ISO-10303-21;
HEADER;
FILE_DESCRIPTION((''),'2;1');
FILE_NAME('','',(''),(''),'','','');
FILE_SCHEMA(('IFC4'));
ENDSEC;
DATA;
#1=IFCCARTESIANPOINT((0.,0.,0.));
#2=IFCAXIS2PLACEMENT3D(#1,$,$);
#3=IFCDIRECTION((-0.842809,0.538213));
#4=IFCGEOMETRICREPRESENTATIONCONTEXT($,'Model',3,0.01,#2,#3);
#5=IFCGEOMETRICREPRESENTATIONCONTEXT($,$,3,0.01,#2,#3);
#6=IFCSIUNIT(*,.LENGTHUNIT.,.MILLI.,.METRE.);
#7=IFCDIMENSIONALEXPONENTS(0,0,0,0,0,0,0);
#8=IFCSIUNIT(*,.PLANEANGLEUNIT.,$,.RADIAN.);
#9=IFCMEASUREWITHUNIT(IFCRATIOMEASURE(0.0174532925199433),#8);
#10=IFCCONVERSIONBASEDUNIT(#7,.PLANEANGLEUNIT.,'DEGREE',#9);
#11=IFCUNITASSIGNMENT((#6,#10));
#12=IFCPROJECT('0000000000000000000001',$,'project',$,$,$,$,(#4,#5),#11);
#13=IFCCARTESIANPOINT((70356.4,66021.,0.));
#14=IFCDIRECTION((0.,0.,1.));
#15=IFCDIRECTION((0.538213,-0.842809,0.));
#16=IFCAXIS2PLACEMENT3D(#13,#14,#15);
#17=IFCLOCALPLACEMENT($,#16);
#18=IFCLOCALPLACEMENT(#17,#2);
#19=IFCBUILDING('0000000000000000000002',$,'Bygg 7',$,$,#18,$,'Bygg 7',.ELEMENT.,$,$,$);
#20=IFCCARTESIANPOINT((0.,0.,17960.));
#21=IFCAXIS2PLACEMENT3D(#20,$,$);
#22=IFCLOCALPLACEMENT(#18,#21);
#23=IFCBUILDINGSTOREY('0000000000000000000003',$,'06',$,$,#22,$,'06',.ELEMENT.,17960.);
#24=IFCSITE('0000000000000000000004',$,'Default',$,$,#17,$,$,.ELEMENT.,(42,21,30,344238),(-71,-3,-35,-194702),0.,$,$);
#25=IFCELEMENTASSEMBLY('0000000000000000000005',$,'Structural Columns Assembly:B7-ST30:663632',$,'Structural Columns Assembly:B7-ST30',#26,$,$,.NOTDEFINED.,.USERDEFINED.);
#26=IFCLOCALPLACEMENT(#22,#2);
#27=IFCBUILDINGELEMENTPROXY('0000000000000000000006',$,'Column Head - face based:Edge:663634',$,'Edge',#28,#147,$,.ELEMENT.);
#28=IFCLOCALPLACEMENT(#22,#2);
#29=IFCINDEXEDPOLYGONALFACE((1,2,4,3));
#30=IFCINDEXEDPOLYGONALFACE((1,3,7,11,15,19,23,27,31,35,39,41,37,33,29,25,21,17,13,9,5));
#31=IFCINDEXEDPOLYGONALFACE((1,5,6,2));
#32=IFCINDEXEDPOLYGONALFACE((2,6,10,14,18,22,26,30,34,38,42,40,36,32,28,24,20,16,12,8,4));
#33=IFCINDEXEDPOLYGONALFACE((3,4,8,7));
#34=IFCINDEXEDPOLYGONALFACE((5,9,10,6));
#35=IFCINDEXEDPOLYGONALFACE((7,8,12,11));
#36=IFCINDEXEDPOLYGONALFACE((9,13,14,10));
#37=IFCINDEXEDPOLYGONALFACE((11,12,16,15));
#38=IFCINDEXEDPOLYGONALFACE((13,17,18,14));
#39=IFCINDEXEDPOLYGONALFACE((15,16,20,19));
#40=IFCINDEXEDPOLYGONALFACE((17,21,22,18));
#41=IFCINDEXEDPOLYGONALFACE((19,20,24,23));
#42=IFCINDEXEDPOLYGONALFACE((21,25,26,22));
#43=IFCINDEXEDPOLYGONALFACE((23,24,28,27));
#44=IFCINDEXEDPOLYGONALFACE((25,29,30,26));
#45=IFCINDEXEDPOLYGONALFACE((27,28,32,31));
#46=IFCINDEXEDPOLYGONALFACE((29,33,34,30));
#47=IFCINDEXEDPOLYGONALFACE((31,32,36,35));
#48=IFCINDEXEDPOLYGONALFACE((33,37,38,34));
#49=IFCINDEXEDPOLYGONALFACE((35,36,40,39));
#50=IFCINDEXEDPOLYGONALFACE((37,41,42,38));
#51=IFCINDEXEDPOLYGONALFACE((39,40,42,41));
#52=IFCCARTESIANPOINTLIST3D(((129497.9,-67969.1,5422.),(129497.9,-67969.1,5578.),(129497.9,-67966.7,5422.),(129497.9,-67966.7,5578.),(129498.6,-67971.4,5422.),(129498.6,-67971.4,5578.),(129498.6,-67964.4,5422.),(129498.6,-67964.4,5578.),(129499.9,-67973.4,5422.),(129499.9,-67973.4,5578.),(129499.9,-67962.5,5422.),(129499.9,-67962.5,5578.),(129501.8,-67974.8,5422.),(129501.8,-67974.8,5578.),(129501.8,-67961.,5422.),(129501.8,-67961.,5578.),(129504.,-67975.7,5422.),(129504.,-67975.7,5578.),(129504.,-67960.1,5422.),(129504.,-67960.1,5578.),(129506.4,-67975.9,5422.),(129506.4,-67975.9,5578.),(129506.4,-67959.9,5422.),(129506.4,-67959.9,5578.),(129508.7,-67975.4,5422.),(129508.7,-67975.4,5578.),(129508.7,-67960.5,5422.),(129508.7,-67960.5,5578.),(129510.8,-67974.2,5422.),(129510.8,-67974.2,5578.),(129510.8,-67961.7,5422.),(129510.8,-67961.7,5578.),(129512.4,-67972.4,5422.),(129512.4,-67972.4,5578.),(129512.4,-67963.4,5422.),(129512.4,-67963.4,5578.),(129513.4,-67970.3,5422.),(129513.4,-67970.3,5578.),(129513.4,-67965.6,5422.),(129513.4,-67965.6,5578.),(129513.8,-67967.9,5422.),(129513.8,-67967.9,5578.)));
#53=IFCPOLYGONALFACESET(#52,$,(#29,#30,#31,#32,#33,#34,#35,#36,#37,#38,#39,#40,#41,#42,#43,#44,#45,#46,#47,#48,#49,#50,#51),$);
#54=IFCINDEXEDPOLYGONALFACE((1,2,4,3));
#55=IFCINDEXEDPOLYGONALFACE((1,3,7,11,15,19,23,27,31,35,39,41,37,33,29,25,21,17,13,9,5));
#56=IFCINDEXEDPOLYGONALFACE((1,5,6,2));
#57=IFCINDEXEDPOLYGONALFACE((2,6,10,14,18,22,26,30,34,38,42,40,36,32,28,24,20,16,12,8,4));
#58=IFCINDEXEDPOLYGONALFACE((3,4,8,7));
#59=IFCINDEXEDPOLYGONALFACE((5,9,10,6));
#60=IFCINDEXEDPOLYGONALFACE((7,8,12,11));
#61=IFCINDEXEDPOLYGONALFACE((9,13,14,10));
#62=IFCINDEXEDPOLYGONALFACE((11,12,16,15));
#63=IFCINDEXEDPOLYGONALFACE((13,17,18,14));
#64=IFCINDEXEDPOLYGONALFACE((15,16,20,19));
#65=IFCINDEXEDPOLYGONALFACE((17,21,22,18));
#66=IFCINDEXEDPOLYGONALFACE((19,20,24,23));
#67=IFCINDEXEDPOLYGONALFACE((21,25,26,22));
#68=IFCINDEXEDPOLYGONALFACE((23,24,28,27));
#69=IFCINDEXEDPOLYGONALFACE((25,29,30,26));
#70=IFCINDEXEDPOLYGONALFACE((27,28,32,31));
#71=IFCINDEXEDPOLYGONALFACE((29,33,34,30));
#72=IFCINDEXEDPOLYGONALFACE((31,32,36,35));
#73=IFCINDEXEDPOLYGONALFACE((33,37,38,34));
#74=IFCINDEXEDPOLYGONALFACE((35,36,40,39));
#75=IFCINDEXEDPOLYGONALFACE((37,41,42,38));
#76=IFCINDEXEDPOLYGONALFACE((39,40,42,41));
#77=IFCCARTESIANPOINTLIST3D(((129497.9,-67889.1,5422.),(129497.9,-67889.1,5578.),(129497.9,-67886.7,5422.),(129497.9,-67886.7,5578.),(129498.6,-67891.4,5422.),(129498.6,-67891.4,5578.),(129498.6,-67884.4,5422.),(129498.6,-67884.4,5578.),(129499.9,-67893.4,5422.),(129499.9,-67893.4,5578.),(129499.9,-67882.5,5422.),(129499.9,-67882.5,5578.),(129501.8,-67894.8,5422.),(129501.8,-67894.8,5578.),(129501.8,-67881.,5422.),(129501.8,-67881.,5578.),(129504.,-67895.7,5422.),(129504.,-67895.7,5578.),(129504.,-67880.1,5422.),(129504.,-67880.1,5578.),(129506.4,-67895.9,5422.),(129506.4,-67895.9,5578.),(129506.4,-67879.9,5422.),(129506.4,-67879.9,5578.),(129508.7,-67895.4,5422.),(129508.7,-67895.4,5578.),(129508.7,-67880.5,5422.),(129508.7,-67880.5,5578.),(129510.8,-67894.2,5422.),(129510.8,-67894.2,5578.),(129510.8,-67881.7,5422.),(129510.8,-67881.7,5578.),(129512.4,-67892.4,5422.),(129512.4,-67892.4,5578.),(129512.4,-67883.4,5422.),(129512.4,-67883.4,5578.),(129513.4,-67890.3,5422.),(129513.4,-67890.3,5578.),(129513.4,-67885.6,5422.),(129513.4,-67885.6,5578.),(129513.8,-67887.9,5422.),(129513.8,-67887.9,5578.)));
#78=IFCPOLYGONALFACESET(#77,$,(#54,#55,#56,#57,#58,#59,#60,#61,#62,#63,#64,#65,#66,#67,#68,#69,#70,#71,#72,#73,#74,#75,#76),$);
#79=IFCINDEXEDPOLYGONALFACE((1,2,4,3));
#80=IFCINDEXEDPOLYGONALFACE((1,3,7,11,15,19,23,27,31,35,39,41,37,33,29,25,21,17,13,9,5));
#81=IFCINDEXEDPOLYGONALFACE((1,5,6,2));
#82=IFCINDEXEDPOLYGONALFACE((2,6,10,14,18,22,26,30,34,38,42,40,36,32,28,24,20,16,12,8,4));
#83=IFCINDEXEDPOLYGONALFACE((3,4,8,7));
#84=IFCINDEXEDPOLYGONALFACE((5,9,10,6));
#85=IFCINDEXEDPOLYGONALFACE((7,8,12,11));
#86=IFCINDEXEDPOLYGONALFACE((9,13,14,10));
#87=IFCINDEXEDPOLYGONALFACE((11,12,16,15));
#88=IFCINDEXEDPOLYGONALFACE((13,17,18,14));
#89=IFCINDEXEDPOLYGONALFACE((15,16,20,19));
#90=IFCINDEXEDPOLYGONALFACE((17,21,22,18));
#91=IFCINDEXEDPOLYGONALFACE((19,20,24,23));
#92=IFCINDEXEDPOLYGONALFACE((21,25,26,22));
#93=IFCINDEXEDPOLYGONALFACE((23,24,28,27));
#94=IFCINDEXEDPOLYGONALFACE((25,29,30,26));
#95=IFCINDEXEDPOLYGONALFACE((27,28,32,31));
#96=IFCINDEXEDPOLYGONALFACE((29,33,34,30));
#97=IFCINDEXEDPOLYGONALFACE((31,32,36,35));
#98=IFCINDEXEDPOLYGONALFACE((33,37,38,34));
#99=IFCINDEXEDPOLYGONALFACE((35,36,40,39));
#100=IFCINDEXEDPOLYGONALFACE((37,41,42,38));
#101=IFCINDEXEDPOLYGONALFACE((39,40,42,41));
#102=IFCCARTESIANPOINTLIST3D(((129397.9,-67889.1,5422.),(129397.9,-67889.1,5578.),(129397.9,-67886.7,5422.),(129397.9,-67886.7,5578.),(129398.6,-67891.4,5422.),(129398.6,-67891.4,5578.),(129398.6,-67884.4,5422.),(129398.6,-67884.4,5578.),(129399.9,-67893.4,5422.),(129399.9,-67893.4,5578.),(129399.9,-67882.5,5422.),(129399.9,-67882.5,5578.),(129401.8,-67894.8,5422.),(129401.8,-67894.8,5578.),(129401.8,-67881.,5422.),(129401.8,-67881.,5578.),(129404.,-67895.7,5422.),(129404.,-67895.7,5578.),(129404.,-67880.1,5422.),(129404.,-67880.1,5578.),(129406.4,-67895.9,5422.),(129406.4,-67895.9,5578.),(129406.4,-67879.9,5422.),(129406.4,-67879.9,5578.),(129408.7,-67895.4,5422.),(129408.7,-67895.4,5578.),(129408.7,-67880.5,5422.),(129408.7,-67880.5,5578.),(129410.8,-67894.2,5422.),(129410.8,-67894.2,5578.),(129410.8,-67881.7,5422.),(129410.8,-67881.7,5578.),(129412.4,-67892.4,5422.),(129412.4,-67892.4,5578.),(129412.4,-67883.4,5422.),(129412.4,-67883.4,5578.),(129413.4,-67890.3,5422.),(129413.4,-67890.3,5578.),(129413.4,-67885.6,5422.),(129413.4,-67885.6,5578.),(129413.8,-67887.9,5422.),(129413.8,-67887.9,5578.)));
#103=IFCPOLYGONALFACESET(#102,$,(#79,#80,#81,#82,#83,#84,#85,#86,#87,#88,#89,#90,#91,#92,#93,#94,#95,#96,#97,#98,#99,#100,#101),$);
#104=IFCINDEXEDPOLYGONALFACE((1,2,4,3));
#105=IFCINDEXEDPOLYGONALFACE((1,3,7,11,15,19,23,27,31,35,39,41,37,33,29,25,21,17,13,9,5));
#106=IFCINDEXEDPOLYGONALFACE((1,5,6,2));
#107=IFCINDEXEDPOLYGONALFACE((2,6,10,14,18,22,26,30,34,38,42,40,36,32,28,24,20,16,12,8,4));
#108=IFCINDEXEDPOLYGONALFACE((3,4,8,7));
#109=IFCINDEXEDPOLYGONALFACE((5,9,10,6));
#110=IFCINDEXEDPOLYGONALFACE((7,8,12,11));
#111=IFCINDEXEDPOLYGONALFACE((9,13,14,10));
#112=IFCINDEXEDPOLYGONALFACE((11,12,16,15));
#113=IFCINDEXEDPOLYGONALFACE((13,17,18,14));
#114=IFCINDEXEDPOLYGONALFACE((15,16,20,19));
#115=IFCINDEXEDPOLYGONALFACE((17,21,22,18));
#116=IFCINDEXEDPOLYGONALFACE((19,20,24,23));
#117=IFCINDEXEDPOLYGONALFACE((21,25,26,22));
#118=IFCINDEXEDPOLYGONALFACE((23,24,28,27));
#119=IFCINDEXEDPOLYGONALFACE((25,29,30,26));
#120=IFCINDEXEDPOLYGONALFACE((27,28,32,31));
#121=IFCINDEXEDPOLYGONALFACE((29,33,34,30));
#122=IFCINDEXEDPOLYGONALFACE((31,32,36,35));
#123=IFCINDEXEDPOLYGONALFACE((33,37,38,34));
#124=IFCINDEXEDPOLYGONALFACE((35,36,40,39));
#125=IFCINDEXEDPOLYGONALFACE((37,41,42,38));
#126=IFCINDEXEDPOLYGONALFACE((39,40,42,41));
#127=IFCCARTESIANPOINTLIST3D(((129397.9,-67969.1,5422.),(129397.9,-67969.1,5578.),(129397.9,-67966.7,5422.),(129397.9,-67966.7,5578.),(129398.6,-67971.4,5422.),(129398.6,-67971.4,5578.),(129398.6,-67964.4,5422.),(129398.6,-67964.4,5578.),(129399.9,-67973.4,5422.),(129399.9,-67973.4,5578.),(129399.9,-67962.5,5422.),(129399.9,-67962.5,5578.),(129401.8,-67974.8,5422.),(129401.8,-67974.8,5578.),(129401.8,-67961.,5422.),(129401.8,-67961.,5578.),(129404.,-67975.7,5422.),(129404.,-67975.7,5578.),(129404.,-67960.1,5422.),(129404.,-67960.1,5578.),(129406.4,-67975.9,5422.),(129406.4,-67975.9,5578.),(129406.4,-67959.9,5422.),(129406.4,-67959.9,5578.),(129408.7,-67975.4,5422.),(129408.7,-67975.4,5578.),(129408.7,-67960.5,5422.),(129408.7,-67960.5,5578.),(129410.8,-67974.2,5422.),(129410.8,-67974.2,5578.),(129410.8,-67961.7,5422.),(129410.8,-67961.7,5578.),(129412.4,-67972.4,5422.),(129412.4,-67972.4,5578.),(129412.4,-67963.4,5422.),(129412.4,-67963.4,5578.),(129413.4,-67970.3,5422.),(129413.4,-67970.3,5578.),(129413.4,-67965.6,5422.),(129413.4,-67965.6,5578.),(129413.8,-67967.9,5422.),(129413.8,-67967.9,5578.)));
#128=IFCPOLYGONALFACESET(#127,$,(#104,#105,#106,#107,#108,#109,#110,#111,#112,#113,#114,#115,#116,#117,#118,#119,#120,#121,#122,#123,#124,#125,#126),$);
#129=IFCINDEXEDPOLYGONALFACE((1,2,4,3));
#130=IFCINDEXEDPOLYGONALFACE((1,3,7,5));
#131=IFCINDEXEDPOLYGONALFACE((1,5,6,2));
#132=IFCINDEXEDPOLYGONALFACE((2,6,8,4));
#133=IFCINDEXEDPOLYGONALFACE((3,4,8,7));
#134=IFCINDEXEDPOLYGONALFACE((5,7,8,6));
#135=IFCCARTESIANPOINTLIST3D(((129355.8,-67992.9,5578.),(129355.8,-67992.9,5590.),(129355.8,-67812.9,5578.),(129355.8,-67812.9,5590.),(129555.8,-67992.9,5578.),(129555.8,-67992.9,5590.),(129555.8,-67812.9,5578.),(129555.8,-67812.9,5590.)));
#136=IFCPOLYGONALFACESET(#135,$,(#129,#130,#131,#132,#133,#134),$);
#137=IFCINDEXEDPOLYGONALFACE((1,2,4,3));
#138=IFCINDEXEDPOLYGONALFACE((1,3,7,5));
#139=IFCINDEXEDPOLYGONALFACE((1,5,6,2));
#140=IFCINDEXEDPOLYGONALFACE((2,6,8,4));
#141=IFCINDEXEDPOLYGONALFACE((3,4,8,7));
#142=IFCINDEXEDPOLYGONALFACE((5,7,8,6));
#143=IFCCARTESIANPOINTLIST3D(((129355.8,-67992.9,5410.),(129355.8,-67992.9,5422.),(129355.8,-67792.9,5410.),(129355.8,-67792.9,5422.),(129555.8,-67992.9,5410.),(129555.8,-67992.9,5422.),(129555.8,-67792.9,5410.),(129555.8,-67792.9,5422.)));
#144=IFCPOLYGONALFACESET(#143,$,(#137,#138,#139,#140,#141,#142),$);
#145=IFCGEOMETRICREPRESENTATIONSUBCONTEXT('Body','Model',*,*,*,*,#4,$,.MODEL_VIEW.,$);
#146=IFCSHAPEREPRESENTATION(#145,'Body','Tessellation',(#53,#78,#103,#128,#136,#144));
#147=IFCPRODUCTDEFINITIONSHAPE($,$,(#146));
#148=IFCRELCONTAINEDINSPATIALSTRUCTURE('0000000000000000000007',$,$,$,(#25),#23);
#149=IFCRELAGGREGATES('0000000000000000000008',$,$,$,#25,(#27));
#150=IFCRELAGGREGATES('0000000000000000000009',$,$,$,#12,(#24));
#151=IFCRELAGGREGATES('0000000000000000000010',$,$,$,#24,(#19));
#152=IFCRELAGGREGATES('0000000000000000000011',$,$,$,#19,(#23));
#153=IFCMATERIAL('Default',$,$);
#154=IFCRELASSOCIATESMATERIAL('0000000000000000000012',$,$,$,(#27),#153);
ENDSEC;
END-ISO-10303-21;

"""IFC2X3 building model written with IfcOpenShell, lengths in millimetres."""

from ifc_helpers import new_model, entity, si_unit, converted_unit, direction, frame, frame_2d, origin, origin_2d_with_axis, place, context, subcontext, project, spatial, rectangle, circle, extrude, source, transform, mapped, material, element, aggregate, save


model = new_model("IFC2X3")

# Units and contexts
model_context = context("Model", 3, precision=0.01, world=origin(), true_north=direction((-0.842809, 0.538213)))
context_of_model = context(None, 3, precision=0.01, world=origin(), true_north=direction((-0.842809, 0.538213)))
body_context = subcontext(model_context, "Body", "Model", "MODEL_VIEW")
ifc_project = project(units=[si_unit("LENGTHUNIT", "METRE", prefix="MILLI"), converted_unit("PLANEANGLEUNIT", "DEGREE", entity("IfcRatioMeasure", 0.0174532925199433), si_unit("PLANEANGLEUNIT", "RADIAN"), dimensions=[0, 0, 0, 0, 0, 0, 0])], contexts=[model_context, context_of_model])

# Site, building, storey
site_placement = place(None, frame((70356.4, 66021.0, 0.0), z_axis=(0.0, 0.0, 1.0), x_axis=(0.538213, -0.842809, 0.0)))
site = spatial("IfcSite", under=ifc_project, at=site_placement, Name="Default", CompositionType="ELEMENT", RefLatitude=(42, 21, 30, 344238), RefLongitude=(-71, -3, -35, -194702), RefElevation=0.0)
building_placement = place(site_placement, origin())
building = spatial("IfcBuilding", under=site, at=building_placement, Name="Bygg 7", LongName="Bygg 7", CompositionType="ELEMENT")
storey_placement = place(building_placement, frame((0.0, 0.0, 17960.0)))
storey = spatial("IfcBuildingStorey", under=building, at=storey_placement, Name="06", LongName="06", CompositionType="ELEMENT", Elevation=17960.0)

# Shared definitions
ifc_material_1 = material(Name="Default")

# Element assembly, building element proxy
shared_shape_1 = source(origin(), body_context, "Body", "SweptSolid", [
    extrude(circle(Radius=8.0, at=frame_2d((0.0, 0.0), x_axis=(1.0, 0.0))), frame((50.0, -135.0, 12.0)), (0.0, 0.0, 1.0), 156.0),
    extrude(circle(Radius=8.0, at=frame_2d((0.0, 0.0), x_axis=(1.0, 0.0))), frame((50.0, -55.0, 12.0)), (0.0, 0.0, 1.0), 156.0),
    extrude(circle(Radius=8.0, at=frame_2d((0.0, 0.0), x_axis=(1.0, 0.0))), frame((-50.0, -55.0, 12.0)), (0.0, 0.0, 1.0), 156.0),
    extrude(circle(Radius=8.0, at=frame_2d((0.0, 0.0), x_axis=(1.0, 0.0))), frame((-50.0, -135.0, 12.0)), (0.0, 0.0, 1.0), 156.0),
    extrude(rectangle(XDim=200.0, YDim=180.0, at=origin_2d_with_axis()), frame((0.0, -70.0, 168.0), z_axis=(0.0, 0.0, 1.0), x_axis=(-1.0, 0.0, 0.0)), (0.0, 0.0, 1.0), 12.0),
    extrude(rectangle(XDim=200.0, YDim=200.0, at=origin_2d_with_axis()), frame((0.0, -60.0, 0.0), z_axis=(0.0, 0.0, 1.0), x_axis=(0.0, 1.0, 0.0)), (0.0, 0.0, 1.0), 12.0),
])
assembly_1_placement = place(storey_placement, origin())
assembly_1 = element("IfcElementAssembly", 1, at=assembly_1_placement, inside=storey, Name="Structural Columns Assembly:B7-ST30:663632", ObjectType="Structural Columns Assembly:B7-ST30", AssemblyPlace="NOTDEFINED", PredefinedType="USERDEFINED")
proxy_1_placement = place(assembly_1_placement, frame((129455.8, -67832.9, 5410.0)))
proxy_1 = element("IfcBuildingElementProxy", 2, at=proxy_1_placement, material=ifc_material_1, Name="Column Head - face based:Edge:663634", ObjectType="Edge", CompositionType="ELEMENT", context=body_context, shape_type="MappedRepresentation", body=[
    mapped(shared_shape_1, transform((0.0, 0.0, 0.0), scale=1.0)),
])
aggregate(assembly_1, [proxy_1])

save(model, "model.ifc")
